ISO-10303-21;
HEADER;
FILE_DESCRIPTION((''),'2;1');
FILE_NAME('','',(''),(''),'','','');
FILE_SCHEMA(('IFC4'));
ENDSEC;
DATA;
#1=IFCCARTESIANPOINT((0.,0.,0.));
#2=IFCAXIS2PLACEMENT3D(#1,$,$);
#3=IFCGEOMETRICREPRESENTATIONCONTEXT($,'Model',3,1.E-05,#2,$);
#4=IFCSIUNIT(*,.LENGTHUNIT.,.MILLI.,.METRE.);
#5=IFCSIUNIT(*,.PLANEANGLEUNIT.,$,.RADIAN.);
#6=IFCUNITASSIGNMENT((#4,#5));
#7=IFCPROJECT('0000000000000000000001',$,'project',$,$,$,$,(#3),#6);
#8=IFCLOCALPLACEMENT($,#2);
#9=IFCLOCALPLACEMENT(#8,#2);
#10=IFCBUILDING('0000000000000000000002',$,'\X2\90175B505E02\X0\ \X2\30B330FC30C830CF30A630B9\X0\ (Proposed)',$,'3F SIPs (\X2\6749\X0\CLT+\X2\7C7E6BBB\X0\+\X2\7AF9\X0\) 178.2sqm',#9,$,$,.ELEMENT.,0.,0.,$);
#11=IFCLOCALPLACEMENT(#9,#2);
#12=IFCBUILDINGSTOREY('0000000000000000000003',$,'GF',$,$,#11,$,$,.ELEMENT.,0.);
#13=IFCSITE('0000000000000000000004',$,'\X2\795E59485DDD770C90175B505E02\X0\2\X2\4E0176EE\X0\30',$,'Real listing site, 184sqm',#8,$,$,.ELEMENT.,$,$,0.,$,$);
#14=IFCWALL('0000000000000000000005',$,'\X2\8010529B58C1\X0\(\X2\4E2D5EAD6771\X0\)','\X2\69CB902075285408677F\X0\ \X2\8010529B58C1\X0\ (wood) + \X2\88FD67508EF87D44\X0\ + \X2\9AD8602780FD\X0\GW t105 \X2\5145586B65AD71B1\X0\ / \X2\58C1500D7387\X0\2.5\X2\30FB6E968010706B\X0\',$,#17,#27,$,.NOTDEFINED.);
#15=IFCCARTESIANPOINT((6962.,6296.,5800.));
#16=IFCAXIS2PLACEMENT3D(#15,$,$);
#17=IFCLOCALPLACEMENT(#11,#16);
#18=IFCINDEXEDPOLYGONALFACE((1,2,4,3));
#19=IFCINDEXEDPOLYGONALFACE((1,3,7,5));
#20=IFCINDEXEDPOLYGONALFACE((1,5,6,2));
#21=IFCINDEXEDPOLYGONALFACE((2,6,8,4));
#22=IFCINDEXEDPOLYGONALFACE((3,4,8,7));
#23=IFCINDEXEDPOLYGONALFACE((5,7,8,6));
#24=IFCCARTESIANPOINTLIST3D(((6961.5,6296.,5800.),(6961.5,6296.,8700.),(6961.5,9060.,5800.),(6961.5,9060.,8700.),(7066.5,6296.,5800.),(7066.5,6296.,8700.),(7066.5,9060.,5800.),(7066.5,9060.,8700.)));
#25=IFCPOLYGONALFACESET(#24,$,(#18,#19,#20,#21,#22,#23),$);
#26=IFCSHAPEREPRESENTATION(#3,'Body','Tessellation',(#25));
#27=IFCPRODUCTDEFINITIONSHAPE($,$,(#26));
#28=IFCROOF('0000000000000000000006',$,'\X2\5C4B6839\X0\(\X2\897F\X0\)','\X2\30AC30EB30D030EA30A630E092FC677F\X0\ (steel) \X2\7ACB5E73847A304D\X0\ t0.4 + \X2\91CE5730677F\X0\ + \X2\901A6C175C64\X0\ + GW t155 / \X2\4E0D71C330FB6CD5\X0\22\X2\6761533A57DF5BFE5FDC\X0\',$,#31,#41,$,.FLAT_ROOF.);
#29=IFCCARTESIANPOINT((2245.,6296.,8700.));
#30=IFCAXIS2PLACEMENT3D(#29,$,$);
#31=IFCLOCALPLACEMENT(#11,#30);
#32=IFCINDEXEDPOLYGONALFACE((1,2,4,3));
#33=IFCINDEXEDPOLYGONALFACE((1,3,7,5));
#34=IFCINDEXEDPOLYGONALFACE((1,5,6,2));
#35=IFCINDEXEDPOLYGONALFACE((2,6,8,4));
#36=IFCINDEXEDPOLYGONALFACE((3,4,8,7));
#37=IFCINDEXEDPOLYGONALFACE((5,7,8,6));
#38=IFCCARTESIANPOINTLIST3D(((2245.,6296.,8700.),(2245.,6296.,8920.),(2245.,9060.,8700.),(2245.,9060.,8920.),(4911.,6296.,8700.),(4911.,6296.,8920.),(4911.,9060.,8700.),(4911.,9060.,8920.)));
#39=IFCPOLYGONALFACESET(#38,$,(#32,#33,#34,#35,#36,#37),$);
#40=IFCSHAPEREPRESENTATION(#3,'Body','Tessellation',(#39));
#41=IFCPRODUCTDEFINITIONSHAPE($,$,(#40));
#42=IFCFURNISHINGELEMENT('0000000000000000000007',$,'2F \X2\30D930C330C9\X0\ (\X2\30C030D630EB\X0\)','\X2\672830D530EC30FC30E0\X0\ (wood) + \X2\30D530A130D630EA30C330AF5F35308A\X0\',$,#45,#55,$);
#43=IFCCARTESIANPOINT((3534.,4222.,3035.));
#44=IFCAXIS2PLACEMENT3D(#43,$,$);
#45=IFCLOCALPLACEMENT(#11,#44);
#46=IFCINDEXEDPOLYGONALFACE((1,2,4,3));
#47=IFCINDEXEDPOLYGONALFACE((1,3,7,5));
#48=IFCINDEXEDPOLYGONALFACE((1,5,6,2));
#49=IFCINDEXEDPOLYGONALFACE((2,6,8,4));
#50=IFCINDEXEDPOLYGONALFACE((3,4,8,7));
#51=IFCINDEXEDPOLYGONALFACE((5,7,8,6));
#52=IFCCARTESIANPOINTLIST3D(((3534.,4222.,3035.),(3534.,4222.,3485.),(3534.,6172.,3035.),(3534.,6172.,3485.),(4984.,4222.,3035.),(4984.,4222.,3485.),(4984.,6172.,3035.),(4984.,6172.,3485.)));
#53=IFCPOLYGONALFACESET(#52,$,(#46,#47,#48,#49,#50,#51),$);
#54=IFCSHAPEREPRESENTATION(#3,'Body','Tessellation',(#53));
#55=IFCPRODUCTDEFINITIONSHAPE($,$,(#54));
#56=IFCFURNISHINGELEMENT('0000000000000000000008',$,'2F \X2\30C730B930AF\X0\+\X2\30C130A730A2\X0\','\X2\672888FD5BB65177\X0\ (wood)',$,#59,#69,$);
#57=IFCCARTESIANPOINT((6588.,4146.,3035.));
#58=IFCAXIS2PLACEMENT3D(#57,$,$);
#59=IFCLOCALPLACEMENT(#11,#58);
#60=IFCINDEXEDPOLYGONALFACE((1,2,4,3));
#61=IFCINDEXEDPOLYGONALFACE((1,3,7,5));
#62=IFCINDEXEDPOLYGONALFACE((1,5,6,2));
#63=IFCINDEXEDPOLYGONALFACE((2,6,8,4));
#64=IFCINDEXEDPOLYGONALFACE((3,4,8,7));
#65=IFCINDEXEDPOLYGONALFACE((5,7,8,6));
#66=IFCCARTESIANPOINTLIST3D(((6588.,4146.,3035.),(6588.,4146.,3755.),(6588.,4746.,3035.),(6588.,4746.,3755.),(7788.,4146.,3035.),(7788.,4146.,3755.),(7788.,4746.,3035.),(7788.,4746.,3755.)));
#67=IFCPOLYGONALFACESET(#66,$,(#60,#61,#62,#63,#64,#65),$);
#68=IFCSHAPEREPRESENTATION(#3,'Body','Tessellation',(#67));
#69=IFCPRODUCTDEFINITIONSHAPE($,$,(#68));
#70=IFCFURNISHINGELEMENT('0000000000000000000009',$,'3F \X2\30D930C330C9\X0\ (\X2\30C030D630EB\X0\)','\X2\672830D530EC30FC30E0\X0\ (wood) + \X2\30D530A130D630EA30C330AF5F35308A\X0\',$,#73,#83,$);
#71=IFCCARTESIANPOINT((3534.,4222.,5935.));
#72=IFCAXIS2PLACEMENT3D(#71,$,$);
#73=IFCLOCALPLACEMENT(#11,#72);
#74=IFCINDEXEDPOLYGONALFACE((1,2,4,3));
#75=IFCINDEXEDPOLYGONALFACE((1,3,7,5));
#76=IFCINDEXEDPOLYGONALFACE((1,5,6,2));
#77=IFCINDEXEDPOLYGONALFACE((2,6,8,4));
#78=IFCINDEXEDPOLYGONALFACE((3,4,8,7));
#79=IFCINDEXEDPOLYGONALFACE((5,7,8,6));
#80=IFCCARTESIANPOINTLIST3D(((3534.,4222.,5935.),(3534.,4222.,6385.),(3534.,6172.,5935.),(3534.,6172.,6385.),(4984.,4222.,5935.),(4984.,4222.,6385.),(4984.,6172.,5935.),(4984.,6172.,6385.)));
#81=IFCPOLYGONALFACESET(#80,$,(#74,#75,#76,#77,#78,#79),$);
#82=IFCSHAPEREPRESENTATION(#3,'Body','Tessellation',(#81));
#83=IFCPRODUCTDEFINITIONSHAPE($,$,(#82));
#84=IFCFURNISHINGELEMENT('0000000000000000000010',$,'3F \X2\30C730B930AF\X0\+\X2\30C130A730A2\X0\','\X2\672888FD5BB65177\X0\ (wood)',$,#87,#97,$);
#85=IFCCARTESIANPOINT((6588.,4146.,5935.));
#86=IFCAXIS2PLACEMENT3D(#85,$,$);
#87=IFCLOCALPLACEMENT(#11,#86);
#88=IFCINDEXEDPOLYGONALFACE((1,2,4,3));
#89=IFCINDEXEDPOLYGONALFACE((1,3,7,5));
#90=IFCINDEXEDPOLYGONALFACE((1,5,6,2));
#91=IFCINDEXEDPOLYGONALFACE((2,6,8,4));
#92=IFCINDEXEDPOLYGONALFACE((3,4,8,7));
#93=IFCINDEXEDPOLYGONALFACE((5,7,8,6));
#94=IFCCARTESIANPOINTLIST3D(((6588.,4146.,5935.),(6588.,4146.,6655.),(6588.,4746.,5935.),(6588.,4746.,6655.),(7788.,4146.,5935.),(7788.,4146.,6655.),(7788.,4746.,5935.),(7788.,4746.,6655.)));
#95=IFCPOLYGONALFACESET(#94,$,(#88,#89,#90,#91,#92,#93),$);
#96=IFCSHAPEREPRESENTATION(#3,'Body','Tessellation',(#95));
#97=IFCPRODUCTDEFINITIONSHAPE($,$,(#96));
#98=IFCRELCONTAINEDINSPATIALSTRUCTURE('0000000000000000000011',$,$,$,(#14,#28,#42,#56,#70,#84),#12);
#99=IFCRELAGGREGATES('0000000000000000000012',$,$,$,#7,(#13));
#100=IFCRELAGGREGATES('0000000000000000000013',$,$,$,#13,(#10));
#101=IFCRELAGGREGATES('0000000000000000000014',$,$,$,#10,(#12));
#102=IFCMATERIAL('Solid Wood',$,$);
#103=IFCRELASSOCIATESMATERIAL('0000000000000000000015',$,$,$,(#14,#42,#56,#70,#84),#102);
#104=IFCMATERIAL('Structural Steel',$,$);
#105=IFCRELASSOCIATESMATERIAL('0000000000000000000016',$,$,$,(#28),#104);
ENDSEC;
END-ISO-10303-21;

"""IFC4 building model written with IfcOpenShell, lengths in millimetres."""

from ifc_helpers import new_model, si_unit, frame, frame_2d, origin, place, context, project, spatial, rectangle, extrude, material, element, save


model = new_model("IFC4")

# Units and contexts
model_context = context("Model", 3, precision=1e-05, world=origin())
ifc_project = project(units=[si_unit("LENGTHUNIT", "METRE", prefix="MILLI"), si_unit("PLANEANGLEUNIT", "RADIAN")], contexts=[model_context])

# Site, building, storey
site_placement = place(None, origin())
site = spatial("IfcSite", under=ifc_project, at=site_placement, Name="神奈川県逗子市2丁目30", ObjectType="Real listing site, 184sqm", CompositionType="ELEMENT", RefElevation=0.0)
building_placement = place(site_placement, origin())
building = spatial("IfcBuilding", under=site, at=building_placement, Name="逗子市 コートハウス (Proposed)", ObjectType="3F SIPs (杉CLT+籾殻+竹) 178.2sqm", CompositionType="ELEMENT", ElevationOfRefHeight=0.0, ElevationOfTerrain=0.0)
storey_placement = place(building_placement, origin())
storey = spatial("IfcBuildingStorey", under=building, at=storey_placement, Name="GF", CompositionType="ELEMENT", Elevation=0.0)

# Shared definitions
ifc_material_1 = material(Name="Solid Wood")

# Wall
wall_1_placement = place(storey_placement, frame((6962.0, 6296.0, 5800.0)))
element("IfcWall", 1, at=wall_1_placement, inside=storey, material=ifc_material_1, Name="耐力壁(中庭東)", Description="構造用合板 耐力壁 (wood) + 製材軸組 + 高性能GW t105 充填断熱 / 壁倍率2.5・準耐火", PredefinedType="NOTDEFINED", context=model_context, shape_type="SweptSolid", body=[
    extrude(rectangle(XDim=105.0, YDim=2764.0, at=frame_2d((52.0, 1382.0))), frame((6962.0, 6296.0, 5800.0)), (0.0, 0.0, 1.0), 2900.0),
])

# Roof
ifc_material_2 = material(Name="Structural Steel")
roof_1_placement = place(storey_placement, frame((2245.0, 6296.0, 8700.0)))
element("IfcRoof", 2, at=roof_1_placement, inside=storey, material=ifc_material_2, Name="屋根(西)", Description="ガルバリウム鋼板 (steel) 立平葺き t0.4 + 野地板 + 通気層 + GW t155 / 不燃・法22条区域対応", PredefinedType="FLAT_ROOF", context=model_context, shape_type="SweptSolid", body=[
    extrude(rectangle(XDim=2666.0, YDim=2764.0, at=frame_2d((1333.0, 1382.0))), frame((2245.0, 6296.0, 8700.0)), (0.0, 0.0, 1.0), 220.0),
])

# Furnishing elements
furnishing_1_placement = place(storey_placement, frame((3534.0, 4222.0, 3035.0)))
element("IfcFurnishingElement", 3, at=furnishing_1_placement, inside=storey, material=ifc_material_1, Name="2F ベッド (ダブル)", Description="木フレーム (wood) + ファブリック張り", context=model_context, shape_type="SweptSolid", body=[
    extrude(rectangle(XDim=1450.0, YDim=1950.0, at=frame_2d((725.0, 975.0))), frame((3534.0, 4222.0, 3035.0)), (0.0, 0.0, 1.0), 450.0),
])
furnishing_2_placement = place(storey_placement, frame((6588.0, 4146.0, 3035.0)))
element("IfcFurnishingElement", 4, at=furnishing_2_placement, inside=storey, material=ifc_material_1, Name="2F デスク+チェア", Description="木製家具 (wood)", context=model_context, shape_type="SweptSolid", body=[
    extrude(rectangle(XDim=1200.0, YDim=600.0, at=frame_2d((600.0, 300.0))), frame((6588.0, 4146.0, 3035.0)), (0.0, 0.0, 1.0), 720.0),
])
furnishing_3_placement = place(storey_placement, frame((3534.0, 4222.0, 5935.0)))
element("IfcFurnishingElement", 5, at=furnishing_3_placement, inside=storey, material=ifc_material_1, Name="3F ベッド (ダブル)", Description="木フレーム (wood) + ファブリック張り", context=model_context, shape_type="SweptSolid", body=[
    extrude(rectangle(XDim=1450.0, YDim=1950.0, at=frame_2d((725.0, 975.0))), frame((3534.0, 4222.0, 5935.0)), (0.0, 0.0, 1.0), 450.0),
])
furnishing_4_placement = place(storey_placement, frame((6588.0, 4146.0, 5935.0)))
element("IfcFurnishingElement", 6, at=furnishing_4_placement, inside=storey, material=ifc_material_1, Name="3F デスク+チェア", Description="木製家具 (wood)", context=model_context, shape_type="SweptSolid", body=[
    extrude(rectangle(XDim=1200.0, YDim=600.0, at=frame_2d((600.0, 300.0))), frame((6588.0, 4146.0, 5935.0)), (0.0, 0.0, 1.0), 720.0),
])

save(model, "model.ifc")
